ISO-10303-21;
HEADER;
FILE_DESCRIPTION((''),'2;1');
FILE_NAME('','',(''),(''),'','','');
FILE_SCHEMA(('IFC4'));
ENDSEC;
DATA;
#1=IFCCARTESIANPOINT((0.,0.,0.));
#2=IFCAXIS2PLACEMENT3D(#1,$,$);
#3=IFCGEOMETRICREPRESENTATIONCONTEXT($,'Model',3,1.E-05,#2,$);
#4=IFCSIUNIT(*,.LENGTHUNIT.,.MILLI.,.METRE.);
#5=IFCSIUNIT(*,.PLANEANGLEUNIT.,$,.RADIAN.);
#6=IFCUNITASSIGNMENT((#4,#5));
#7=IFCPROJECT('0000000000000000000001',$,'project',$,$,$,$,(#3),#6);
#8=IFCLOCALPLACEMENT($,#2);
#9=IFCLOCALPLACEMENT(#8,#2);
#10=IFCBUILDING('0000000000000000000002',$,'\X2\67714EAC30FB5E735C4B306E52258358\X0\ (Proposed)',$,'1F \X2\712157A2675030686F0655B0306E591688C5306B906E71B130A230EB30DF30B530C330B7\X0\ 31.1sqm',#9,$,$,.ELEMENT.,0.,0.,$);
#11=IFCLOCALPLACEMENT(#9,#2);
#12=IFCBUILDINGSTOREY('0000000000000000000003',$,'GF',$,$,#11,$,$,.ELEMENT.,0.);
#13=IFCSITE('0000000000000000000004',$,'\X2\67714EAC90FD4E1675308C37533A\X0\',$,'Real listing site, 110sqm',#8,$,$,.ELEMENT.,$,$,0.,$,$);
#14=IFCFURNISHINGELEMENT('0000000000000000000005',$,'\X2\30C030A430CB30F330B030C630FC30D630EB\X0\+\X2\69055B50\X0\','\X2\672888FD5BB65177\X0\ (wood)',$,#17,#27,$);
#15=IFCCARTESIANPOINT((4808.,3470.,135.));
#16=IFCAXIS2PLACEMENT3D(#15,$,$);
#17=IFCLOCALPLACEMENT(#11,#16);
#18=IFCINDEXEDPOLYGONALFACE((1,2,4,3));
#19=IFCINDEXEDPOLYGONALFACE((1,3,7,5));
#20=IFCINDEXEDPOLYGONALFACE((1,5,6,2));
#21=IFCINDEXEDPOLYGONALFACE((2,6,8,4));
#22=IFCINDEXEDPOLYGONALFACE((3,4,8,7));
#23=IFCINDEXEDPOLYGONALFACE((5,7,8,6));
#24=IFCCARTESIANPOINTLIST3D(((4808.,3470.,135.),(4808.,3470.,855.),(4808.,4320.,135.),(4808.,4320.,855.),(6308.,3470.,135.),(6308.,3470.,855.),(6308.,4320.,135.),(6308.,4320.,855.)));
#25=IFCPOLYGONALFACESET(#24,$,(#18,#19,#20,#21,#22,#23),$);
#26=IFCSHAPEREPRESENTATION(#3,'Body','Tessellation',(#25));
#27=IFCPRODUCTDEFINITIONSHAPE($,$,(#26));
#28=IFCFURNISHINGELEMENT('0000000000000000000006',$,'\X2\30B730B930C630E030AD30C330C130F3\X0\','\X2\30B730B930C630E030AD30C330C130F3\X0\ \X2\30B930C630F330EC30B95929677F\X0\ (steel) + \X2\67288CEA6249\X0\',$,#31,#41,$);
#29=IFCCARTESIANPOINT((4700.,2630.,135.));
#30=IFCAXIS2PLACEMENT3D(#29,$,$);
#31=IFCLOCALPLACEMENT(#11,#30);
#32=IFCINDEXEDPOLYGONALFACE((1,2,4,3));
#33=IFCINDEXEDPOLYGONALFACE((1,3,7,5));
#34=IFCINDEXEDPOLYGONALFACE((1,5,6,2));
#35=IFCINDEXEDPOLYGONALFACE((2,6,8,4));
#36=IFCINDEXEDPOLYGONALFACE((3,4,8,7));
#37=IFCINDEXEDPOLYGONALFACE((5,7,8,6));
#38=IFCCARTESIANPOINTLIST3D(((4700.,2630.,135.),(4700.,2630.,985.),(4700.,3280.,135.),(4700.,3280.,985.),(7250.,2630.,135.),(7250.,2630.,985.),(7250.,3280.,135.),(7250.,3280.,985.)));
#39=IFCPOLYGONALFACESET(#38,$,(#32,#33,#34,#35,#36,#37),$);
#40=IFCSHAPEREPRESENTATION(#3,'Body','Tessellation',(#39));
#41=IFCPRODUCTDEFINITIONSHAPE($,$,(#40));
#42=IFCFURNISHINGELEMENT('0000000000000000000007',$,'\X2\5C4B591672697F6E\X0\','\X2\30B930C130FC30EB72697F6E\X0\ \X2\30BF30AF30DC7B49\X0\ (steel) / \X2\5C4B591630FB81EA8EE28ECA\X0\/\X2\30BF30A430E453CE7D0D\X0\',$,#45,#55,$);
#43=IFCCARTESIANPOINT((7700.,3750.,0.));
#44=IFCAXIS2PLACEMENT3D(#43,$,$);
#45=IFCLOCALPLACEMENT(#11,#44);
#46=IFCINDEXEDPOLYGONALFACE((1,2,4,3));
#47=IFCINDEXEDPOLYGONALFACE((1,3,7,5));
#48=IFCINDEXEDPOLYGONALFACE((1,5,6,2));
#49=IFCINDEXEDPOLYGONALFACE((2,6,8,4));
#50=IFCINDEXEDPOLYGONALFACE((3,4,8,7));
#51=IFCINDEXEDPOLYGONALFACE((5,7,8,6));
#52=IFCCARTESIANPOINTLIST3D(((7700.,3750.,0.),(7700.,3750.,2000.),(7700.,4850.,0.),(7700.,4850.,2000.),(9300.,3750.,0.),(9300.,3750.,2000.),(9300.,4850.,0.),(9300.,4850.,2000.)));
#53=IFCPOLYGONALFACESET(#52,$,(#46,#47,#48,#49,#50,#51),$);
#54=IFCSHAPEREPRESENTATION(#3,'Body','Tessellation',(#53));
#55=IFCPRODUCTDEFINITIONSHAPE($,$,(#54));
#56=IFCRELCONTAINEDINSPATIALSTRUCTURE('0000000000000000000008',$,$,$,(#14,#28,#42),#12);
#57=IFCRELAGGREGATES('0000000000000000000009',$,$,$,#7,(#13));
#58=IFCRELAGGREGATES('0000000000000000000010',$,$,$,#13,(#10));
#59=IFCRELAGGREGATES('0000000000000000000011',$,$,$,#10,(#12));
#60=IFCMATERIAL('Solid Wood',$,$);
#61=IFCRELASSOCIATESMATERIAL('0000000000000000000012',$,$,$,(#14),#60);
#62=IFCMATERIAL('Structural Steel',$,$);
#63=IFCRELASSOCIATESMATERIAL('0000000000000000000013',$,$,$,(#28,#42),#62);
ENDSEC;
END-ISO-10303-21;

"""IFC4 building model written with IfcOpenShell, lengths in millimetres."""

from ifc_helpers import new_model, si_unit, frame, frame_2d, origin, place, context, project, spatial, rectangle, extrude, material, element, save


model = new_model("IFC4")

# Units and contexts
model_context = context("Model", 3, precision=1e-05, world=origin())
ifc_project = project(units=[si_unit("LENGTHUNIT", "METRE", prefix="MILLI"), si_unit("PLANEANGLEUNIT", "RADIAN")], contexts=[model_context])

# Site, building, storey
site_placement = place(None, origin())
site = spatial("IfcSite", under=ifc_project, at=site_placement, Name="東京都世田谷区", ObjectType="Real listing site, 110sqm", CompositionType="ELEMENT", RefElevation=0.0)
building_placement = place(site_placement, origin())
building = spatial("IfcBuilding", under=site, at=building_placement, Name="東京・平屋の別荘 (Proposed)", ObjectType="1F 無垢材と漆喰の外装に遮熱アルミサッシ 31.1sqm", CompositionType="ELEMENT", ElevationOfRefHeight=0.0, ElevationOfTerrain=0.0)
storey_placement = place(building_placement, origin())
storey = spatial("IfcBuildingStorey", under=building, at=storey_placement, Name="GF", CompositionType="ELEMENT", Elevation=0.0)

# Shared definitions
ifc_material_1 = material(Name="Solid Wood")

# Shared definitions
ifc_material_2 = material(Name="Structural Steel")

# Furnishing elements
furnishing_1_placement = place(storey_placement, frame((4808.0, 3470.0, 135.0)))
element("IfcFurnishingElement", 1, at=furnishing_1_placement, inside=storey, material=ifc_material_1, Name="ダイニングテーブル+椅子", Description="木製家具 (wood)", context=model_context, shape_type="SweptSolid", body=[
    extrude(rectangle(XDim=1500.0, YDim=850.0, at=frame_2d((750.0, 425.0))), frame((4808.0, 3470.0, 135.0)), (0.0, 0.0, 1.0), 720.0),
])
furnishing_2_placement = place(storey_placement, frame((4700.0, 2630.0, 135.0)))
element("IfcFurnishingElement", 2, at=furnishing_2_placement, inside=storey, material=ifc_material_2, Name="システムキッチン", Description="システムキッチン ステンレス天板 (steel) + 木質扉", context=model_context, shape_type="SweptSolid", body=[
    extrude(rectangle(XDim=2550.0, YDim=650.0, at=frame_2d((1275.0, 325.0))), frame((4700.0, 2630.0, 135.0)), (0.0, 0.0, 1.0), 850.0),
])
furnishing_3_placement = place(storey_placement, frame((7700.0, 3750.0, 0.0)))
element("IfcFurnishingElement", 3, at=furnishing_3_placement, inside=storey, material=ifc_material_2, Name="屋外物置", Description="スチール物置 タクボ等 (steel) / 屋外・自転車/タイヤ収納", context=model_context, shape_type="SweptSolid", body=[
    extrude(rectangle(XDim=1600.0, YDim=1100.0, at=frame_2d((800.0, 550.0))), frame((7700.0, 3750.0, 0.0)), (0.0, 0.0, 1.0), 2000.0),
])

save(model, "model.ifc")
